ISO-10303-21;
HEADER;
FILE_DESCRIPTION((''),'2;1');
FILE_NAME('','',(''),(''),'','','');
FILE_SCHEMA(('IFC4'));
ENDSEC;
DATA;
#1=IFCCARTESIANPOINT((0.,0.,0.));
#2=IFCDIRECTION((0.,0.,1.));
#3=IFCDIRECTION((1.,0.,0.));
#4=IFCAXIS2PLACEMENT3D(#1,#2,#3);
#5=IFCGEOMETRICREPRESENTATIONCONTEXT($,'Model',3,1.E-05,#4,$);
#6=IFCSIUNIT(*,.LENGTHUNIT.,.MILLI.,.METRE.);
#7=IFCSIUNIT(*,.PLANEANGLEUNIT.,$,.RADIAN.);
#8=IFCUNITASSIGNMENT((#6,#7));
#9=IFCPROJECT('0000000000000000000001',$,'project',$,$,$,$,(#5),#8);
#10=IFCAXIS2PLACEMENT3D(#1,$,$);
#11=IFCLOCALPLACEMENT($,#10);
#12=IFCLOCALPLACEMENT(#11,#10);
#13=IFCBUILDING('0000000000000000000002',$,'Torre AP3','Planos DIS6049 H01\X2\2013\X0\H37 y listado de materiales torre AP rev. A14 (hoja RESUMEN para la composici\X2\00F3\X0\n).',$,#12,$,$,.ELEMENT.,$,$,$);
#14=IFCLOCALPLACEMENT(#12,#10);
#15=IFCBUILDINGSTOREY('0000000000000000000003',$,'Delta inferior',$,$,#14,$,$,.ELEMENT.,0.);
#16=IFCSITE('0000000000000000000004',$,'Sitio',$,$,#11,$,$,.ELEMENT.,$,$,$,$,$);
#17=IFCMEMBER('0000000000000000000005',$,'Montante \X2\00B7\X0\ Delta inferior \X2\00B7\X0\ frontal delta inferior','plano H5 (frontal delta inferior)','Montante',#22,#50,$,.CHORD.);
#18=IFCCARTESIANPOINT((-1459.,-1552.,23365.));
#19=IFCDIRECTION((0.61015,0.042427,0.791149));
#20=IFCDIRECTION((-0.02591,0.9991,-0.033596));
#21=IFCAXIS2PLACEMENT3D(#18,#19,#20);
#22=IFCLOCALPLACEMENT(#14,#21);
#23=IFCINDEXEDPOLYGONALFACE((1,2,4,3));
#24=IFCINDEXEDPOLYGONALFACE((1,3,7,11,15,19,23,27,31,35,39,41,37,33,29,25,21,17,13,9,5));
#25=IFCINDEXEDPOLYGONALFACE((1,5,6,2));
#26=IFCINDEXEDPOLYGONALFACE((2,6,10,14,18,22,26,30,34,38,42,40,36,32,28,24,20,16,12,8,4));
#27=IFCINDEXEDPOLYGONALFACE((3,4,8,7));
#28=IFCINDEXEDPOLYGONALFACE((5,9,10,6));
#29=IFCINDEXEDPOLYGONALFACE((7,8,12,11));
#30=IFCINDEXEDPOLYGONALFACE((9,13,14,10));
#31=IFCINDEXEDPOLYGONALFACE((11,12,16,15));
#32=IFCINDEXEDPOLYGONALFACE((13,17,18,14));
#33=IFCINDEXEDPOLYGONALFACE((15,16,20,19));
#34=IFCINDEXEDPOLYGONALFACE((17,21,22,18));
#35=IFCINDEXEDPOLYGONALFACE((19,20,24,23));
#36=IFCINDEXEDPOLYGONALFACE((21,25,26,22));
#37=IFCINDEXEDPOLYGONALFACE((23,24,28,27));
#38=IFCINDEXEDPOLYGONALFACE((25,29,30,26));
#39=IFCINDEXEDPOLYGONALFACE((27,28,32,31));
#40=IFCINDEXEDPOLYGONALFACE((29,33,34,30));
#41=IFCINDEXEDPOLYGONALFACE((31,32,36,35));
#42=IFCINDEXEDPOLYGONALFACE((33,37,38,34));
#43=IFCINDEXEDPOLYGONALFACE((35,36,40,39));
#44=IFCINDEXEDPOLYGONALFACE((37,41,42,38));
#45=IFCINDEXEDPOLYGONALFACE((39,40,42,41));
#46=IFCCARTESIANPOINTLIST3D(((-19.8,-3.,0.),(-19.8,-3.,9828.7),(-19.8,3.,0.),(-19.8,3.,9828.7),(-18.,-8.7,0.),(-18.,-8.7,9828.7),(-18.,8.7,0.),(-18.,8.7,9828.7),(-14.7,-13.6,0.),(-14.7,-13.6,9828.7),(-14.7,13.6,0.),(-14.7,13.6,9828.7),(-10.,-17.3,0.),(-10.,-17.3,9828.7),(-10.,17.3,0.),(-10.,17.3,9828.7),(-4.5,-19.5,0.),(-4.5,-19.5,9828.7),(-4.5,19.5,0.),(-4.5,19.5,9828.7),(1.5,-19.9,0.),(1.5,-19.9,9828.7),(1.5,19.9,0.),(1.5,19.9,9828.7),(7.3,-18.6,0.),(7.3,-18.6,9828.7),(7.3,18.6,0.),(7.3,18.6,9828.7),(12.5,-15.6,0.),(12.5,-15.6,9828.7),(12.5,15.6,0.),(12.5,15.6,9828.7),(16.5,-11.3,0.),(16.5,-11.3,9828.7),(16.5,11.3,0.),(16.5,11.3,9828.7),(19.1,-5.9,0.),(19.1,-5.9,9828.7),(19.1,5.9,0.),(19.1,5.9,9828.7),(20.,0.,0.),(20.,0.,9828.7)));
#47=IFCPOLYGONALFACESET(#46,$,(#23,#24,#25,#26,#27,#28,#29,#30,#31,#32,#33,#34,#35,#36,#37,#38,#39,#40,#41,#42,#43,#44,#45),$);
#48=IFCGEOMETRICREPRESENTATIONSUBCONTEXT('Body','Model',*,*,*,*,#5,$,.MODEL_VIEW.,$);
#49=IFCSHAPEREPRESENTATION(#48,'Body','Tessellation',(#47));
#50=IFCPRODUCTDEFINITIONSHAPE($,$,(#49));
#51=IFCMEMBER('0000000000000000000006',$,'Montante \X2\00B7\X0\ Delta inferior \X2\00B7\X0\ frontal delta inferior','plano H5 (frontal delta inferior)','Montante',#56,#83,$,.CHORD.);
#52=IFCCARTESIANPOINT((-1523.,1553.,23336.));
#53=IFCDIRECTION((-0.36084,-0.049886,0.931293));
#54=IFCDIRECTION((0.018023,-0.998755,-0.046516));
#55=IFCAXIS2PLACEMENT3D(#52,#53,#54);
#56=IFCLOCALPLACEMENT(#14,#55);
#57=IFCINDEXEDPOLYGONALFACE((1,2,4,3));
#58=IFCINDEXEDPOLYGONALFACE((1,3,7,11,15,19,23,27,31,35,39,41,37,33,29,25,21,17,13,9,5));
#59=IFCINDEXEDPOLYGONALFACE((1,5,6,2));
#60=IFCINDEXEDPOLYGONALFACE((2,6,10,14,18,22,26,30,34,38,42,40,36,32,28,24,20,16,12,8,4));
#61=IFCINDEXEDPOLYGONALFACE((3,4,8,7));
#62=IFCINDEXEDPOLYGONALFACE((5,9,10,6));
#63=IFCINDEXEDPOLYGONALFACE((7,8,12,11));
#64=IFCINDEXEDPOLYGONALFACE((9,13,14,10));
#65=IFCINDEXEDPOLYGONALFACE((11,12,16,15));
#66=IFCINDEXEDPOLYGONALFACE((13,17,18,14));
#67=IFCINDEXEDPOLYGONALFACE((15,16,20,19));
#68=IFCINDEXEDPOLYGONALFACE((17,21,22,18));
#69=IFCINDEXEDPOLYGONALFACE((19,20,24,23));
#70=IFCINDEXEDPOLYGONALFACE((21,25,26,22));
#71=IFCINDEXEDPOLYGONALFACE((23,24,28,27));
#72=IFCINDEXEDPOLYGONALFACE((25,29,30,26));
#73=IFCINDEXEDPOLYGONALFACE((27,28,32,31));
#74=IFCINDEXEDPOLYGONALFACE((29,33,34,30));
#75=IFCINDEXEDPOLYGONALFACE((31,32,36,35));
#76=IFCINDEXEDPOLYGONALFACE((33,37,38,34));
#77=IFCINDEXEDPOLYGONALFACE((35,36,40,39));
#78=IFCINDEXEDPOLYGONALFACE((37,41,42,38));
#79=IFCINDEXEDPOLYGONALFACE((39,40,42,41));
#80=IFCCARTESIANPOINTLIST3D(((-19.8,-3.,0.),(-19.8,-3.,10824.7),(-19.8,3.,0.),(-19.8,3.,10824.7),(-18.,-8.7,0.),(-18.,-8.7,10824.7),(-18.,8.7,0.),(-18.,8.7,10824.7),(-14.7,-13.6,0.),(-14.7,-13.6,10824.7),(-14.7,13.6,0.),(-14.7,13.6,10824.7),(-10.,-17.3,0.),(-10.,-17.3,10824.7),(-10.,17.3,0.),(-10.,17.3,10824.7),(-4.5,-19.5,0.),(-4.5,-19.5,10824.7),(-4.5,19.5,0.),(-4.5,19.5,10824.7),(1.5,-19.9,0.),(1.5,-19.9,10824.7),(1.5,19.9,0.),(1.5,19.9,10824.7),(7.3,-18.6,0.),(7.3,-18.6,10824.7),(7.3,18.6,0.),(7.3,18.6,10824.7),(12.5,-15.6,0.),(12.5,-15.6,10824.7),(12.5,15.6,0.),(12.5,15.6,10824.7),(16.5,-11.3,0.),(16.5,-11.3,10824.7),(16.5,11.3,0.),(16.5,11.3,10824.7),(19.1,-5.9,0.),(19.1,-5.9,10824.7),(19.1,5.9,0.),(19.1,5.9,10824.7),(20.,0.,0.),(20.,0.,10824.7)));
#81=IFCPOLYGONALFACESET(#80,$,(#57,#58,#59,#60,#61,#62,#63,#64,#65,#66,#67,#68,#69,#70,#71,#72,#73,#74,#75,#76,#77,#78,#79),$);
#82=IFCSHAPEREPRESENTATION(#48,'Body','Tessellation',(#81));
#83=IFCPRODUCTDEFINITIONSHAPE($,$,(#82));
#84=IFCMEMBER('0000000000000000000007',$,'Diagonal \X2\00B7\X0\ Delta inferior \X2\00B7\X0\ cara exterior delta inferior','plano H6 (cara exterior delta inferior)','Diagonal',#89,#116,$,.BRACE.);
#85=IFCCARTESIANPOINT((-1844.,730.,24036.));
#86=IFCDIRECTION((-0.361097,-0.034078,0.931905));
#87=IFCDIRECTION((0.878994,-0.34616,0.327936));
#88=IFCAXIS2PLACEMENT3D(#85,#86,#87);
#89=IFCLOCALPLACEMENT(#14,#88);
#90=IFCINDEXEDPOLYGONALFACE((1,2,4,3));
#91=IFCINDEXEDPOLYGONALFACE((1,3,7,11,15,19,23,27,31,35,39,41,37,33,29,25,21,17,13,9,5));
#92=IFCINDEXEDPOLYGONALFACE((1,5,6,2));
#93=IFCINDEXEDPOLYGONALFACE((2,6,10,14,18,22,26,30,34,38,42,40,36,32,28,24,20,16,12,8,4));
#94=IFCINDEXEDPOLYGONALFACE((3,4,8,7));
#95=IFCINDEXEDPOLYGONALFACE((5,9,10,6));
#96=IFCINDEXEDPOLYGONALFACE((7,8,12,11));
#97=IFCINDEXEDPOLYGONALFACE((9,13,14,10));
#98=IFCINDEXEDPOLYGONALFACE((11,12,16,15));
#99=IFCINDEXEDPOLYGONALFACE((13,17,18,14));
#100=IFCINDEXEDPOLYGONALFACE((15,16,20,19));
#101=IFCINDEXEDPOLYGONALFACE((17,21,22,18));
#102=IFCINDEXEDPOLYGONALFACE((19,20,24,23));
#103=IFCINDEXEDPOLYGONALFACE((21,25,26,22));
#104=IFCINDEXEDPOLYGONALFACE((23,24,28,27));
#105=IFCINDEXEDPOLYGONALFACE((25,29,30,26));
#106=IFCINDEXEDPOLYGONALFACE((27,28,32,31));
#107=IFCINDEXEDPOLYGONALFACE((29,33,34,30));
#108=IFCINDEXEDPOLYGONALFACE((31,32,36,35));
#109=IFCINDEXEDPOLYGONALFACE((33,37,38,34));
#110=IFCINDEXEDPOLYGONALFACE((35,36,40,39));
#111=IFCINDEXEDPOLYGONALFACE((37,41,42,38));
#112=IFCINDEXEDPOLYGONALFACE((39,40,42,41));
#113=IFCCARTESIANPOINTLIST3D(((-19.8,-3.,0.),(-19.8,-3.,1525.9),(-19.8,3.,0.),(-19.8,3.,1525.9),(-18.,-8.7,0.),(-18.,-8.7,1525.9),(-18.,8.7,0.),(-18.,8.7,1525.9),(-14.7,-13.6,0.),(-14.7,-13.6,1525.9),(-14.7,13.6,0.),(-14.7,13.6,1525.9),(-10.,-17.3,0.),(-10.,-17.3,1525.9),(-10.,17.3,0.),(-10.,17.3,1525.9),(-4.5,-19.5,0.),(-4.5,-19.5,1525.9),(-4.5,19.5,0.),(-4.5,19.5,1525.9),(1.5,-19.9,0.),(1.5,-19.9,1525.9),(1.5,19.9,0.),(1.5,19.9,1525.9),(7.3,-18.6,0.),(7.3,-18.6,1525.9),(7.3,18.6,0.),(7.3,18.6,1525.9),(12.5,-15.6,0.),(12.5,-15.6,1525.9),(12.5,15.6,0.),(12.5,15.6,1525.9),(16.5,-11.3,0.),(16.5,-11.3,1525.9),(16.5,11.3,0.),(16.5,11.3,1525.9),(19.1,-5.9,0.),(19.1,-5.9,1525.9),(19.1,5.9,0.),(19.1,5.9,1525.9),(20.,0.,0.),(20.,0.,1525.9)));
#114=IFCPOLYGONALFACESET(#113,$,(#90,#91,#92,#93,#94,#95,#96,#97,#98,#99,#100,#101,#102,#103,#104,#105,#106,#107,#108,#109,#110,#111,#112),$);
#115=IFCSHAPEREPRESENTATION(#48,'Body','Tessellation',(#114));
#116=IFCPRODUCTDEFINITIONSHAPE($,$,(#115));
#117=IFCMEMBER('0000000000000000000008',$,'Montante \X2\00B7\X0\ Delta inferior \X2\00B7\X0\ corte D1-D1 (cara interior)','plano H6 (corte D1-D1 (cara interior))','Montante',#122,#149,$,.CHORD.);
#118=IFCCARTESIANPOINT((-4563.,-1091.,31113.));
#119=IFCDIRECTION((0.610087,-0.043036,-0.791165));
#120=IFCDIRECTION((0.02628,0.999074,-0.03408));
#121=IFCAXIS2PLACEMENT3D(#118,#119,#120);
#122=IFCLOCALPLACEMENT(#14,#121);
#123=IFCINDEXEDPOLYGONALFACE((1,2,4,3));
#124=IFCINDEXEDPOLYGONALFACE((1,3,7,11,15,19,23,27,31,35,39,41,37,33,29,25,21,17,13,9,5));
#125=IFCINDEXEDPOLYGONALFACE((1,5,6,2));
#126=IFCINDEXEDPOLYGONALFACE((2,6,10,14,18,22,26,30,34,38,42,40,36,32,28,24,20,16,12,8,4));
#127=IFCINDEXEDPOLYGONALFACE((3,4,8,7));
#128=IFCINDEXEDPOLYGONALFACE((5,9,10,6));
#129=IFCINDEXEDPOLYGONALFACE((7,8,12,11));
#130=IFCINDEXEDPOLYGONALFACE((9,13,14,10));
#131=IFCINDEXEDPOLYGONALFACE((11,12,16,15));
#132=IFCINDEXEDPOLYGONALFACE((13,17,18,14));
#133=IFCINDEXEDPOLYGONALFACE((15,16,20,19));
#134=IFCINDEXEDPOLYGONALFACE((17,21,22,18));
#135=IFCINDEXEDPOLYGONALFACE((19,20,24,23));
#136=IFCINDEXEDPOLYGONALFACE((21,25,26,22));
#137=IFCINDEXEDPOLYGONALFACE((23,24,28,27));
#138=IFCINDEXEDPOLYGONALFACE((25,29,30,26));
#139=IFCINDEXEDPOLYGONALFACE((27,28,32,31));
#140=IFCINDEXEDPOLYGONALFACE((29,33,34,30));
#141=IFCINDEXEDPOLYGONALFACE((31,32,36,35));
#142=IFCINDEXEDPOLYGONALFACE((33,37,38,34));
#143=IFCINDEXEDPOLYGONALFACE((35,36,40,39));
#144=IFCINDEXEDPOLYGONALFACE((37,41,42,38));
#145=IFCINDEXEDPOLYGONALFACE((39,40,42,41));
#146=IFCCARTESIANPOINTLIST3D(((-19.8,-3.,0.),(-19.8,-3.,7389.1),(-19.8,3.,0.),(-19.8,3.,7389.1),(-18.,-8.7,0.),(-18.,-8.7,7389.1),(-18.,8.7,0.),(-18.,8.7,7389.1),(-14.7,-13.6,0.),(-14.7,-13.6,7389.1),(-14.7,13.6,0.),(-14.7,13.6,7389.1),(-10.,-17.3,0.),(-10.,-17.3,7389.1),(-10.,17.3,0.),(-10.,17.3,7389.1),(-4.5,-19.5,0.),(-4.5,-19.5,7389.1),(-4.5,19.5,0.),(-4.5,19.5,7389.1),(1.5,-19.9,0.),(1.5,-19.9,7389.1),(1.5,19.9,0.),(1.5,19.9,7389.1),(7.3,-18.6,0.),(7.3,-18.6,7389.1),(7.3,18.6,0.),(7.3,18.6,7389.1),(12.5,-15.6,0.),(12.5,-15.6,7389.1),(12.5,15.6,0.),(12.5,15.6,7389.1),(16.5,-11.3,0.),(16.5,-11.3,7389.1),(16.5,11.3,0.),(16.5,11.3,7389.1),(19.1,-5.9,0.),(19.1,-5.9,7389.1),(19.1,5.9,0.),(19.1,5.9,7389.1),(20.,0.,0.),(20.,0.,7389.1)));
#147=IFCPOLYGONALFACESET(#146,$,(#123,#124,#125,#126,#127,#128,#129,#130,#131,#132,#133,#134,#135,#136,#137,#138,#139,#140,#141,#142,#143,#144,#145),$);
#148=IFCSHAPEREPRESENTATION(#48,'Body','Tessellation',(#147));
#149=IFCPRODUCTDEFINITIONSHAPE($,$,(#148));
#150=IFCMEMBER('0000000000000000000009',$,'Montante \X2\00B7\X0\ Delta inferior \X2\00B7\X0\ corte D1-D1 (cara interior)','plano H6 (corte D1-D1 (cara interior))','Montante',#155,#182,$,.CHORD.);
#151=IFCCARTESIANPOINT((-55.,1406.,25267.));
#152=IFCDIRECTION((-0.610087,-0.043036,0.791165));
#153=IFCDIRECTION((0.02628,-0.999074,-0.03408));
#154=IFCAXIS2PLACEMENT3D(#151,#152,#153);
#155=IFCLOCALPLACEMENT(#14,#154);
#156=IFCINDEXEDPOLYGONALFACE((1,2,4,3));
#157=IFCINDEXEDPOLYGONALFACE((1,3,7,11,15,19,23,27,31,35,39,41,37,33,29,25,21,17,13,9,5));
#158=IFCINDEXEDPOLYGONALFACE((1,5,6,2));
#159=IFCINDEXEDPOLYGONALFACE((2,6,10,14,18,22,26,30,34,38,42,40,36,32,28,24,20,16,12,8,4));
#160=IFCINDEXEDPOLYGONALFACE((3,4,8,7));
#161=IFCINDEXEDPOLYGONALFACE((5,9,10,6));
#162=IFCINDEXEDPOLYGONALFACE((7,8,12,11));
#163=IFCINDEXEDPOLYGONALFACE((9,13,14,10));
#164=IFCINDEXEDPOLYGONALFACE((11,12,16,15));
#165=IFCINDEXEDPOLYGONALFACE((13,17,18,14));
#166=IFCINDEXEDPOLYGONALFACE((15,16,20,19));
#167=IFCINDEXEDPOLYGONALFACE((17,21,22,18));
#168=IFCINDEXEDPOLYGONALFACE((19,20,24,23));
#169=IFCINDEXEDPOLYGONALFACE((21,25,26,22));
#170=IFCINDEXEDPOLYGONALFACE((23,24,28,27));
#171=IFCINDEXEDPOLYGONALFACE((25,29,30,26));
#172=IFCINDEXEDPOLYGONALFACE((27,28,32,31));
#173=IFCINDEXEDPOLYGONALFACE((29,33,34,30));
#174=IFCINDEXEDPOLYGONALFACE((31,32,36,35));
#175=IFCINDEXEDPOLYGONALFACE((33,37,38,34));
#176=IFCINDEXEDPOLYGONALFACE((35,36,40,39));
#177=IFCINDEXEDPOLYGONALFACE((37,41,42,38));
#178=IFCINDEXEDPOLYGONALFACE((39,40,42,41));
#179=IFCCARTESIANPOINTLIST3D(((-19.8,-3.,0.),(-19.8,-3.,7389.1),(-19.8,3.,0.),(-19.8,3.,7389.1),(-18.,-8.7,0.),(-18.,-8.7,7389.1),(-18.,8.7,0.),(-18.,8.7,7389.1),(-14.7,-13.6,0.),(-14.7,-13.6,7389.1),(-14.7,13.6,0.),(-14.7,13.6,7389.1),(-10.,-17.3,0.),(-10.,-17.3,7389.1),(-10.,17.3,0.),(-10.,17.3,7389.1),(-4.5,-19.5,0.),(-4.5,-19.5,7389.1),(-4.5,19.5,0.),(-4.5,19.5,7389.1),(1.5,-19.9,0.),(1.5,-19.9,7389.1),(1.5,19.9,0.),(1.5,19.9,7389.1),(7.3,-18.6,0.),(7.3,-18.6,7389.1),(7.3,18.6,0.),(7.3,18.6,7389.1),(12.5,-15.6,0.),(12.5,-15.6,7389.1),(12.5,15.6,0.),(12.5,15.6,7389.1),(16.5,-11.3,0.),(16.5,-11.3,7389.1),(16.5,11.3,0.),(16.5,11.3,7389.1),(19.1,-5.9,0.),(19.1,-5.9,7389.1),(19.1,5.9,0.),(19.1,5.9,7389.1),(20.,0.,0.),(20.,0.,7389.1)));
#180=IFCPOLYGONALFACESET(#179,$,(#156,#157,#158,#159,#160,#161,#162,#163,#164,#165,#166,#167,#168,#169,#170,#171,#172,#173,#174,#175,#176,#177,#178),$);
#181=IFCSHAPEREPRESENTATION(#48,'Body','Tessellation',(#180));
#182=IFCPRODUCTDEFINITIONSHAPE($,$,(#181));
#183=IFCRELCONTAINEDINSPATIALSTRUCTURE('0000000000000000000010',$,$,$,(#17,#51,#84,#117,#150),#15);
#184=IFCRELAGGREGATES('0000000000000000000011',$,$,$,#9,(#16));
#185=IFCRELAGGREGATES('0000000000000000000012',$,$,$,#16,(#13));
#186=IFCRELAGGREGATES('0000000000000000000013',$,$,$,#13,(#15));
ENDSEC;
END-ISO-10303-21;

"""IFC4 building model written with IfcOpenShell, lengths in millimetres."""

from ifc_helpers import new_model, si_unit, frame, origin, origin_with_axes, place, context, subcontext, project, spatial, circle, extrude, element, save


model = new_model("IFC4")

# Units and contexts
model_context = context("Model", 3, precision=1e-05, world=origin_with_axes())
body_context = subcontext(model_context, "Body", "Model", "MODEL_VIEW")
ifc_project = project(units=[si_unit("LENGTHUNIT", "METRE", prefix="MILLI"), si_unit("PLANEANGLEUNIT", "RADIAN")], contexts=[model_context])

# Site, building, storey
site_placement = place(None, origin())
site = spatial("IfcSite", under=ifc_project, at=site_placement, Name="Sitio", CompositionType="ELEMENT")
building_placement = place(site_placement, origin())
building = spatial("IfcBuilding", under=site, at=building_placement, Name="Torre AP3", Description="Planos DIS6049 H01–H37 y listado de materiales torre AP rev. A14 (hoja RESUMEN para la composición).", CompositionType="ELEMENT")
storey_placement = place(building_placement, origin())
storey = spatial("IfcBuildingStorey", under=building, at=storey_placement, Name="Delta inferior", CompositionType="ELEMENT", Elevation=0.0)

# Members
for number, where, z_axis, x_axis, name in (
    (1, (-1459.0, -1552.0, 23365.0), (0.61015, 0.042427, 0.791149), (-0.02591, 0.9991, -0.033596), "Montante · Delta inferior · frontal delta inferior"),
):
    element("IfcMember", number, at=place(storey_placement, frame(where, z_axis=z_axis, x_axis=x_axis)), inside=storey, Name=name, Description="plano H5 (frontal delta inferior)", ObjectType="Montante", PredefinedType="CHORD", context=body_context, shape_type="SweptSolid", body=[
        extrude(circle(Radius=20.0), None, (0.0, 0.0, 1.0), 9828.7),
    ])
for number, where, z_axis, x_axis, name in (
    (2, (-1523.0, 1553.0, 23336.0), (-0.36084, -0.049886, 0.931293), (0.018023, -0.998755, -0.046516), "Montante · Delta inferior · frontal delta inferior"),
):
    element("IfcMember", number, at=place(storey_placement, frame(where, z_axis=z_axis, x_axis=x_axis)), inside=storey, Name=name, Description="plano H5 (frontal delta inferior)", ObjectType="Montante", PredefinedType="CHORD", context=body_context, shape_type="SweptSolid", body=[
        extrude(circle(Radius=20.0), None, (0.0, 0.0, 1.0), 10824.7),
    ])
member_1_placement = place(storey_placement, frame((-1844.0, 730.0, 24036.0), z_axis=(-0.361097, -0.034078, 0.931905), x_axis=(0.878994, -0.34616, 0.327936)))
element("IfcMember", 3, at=member_1_placement, inside=storey, Name="Diagonal · Delta inferior · cara exterior delta inferior", Description="plano H6 (cara exterior delta inferior)", ObjectType="Diagonal", PredefinedType="BRACE", context=body_context, shape_type="SweptSolid", body=[
    extrude(circle(Radius=20.0), None, (0.0, 0.0, 1.0), 1525.9),
])
member_2_placement = place(storey_placement, frame((-4563.0, -1091.0, 31113.0), z_axis=(0.610087, -0.043036, -0.791165), x_axis=(0.02628, 0.999074, -0.03408)))
element("IfcMember", 4, at=member_2_placement, inside=storey, Name="Montante · Delta inferior · corte D1-D1 (cara interior)", Description="plano H6 (corte D1-D1 (cara interior))", ObjectType="Montante", PredefinedType="CHORD", context=body_context, shape_type="SweptSolid", body=[
    extrude(circle(Radius=20.0), None, (0.0, 0.0, 1.0), 7389.1),
])
for number, where, z_axis, x_axis, name in (
    (5, (-55.0, 1406.0, 25267.0), (-0.610087, -0.043036, 0.791165), (0.02628, -0.999074, -0.03408), "Montante · Delta inferior · corte D1-D1 (cara interior)"),
):
    element("IfcMember", number, at=place(storey_placement, frame(where, z_axis=z_axis, x_axis=x_axis)), inside=storey, Name=name, Description="plano H6 (corte D1-D1 (cara interior))", ObjectType="Montante", PredefinedType="CHORD", context=body_context, shape_type="SweptSolid", body=[
        extrude(circle(Radius=20.0), None, (0.0, 0.0, 1.0), 7389.1),
    ])

save(model, "model.ifc")
